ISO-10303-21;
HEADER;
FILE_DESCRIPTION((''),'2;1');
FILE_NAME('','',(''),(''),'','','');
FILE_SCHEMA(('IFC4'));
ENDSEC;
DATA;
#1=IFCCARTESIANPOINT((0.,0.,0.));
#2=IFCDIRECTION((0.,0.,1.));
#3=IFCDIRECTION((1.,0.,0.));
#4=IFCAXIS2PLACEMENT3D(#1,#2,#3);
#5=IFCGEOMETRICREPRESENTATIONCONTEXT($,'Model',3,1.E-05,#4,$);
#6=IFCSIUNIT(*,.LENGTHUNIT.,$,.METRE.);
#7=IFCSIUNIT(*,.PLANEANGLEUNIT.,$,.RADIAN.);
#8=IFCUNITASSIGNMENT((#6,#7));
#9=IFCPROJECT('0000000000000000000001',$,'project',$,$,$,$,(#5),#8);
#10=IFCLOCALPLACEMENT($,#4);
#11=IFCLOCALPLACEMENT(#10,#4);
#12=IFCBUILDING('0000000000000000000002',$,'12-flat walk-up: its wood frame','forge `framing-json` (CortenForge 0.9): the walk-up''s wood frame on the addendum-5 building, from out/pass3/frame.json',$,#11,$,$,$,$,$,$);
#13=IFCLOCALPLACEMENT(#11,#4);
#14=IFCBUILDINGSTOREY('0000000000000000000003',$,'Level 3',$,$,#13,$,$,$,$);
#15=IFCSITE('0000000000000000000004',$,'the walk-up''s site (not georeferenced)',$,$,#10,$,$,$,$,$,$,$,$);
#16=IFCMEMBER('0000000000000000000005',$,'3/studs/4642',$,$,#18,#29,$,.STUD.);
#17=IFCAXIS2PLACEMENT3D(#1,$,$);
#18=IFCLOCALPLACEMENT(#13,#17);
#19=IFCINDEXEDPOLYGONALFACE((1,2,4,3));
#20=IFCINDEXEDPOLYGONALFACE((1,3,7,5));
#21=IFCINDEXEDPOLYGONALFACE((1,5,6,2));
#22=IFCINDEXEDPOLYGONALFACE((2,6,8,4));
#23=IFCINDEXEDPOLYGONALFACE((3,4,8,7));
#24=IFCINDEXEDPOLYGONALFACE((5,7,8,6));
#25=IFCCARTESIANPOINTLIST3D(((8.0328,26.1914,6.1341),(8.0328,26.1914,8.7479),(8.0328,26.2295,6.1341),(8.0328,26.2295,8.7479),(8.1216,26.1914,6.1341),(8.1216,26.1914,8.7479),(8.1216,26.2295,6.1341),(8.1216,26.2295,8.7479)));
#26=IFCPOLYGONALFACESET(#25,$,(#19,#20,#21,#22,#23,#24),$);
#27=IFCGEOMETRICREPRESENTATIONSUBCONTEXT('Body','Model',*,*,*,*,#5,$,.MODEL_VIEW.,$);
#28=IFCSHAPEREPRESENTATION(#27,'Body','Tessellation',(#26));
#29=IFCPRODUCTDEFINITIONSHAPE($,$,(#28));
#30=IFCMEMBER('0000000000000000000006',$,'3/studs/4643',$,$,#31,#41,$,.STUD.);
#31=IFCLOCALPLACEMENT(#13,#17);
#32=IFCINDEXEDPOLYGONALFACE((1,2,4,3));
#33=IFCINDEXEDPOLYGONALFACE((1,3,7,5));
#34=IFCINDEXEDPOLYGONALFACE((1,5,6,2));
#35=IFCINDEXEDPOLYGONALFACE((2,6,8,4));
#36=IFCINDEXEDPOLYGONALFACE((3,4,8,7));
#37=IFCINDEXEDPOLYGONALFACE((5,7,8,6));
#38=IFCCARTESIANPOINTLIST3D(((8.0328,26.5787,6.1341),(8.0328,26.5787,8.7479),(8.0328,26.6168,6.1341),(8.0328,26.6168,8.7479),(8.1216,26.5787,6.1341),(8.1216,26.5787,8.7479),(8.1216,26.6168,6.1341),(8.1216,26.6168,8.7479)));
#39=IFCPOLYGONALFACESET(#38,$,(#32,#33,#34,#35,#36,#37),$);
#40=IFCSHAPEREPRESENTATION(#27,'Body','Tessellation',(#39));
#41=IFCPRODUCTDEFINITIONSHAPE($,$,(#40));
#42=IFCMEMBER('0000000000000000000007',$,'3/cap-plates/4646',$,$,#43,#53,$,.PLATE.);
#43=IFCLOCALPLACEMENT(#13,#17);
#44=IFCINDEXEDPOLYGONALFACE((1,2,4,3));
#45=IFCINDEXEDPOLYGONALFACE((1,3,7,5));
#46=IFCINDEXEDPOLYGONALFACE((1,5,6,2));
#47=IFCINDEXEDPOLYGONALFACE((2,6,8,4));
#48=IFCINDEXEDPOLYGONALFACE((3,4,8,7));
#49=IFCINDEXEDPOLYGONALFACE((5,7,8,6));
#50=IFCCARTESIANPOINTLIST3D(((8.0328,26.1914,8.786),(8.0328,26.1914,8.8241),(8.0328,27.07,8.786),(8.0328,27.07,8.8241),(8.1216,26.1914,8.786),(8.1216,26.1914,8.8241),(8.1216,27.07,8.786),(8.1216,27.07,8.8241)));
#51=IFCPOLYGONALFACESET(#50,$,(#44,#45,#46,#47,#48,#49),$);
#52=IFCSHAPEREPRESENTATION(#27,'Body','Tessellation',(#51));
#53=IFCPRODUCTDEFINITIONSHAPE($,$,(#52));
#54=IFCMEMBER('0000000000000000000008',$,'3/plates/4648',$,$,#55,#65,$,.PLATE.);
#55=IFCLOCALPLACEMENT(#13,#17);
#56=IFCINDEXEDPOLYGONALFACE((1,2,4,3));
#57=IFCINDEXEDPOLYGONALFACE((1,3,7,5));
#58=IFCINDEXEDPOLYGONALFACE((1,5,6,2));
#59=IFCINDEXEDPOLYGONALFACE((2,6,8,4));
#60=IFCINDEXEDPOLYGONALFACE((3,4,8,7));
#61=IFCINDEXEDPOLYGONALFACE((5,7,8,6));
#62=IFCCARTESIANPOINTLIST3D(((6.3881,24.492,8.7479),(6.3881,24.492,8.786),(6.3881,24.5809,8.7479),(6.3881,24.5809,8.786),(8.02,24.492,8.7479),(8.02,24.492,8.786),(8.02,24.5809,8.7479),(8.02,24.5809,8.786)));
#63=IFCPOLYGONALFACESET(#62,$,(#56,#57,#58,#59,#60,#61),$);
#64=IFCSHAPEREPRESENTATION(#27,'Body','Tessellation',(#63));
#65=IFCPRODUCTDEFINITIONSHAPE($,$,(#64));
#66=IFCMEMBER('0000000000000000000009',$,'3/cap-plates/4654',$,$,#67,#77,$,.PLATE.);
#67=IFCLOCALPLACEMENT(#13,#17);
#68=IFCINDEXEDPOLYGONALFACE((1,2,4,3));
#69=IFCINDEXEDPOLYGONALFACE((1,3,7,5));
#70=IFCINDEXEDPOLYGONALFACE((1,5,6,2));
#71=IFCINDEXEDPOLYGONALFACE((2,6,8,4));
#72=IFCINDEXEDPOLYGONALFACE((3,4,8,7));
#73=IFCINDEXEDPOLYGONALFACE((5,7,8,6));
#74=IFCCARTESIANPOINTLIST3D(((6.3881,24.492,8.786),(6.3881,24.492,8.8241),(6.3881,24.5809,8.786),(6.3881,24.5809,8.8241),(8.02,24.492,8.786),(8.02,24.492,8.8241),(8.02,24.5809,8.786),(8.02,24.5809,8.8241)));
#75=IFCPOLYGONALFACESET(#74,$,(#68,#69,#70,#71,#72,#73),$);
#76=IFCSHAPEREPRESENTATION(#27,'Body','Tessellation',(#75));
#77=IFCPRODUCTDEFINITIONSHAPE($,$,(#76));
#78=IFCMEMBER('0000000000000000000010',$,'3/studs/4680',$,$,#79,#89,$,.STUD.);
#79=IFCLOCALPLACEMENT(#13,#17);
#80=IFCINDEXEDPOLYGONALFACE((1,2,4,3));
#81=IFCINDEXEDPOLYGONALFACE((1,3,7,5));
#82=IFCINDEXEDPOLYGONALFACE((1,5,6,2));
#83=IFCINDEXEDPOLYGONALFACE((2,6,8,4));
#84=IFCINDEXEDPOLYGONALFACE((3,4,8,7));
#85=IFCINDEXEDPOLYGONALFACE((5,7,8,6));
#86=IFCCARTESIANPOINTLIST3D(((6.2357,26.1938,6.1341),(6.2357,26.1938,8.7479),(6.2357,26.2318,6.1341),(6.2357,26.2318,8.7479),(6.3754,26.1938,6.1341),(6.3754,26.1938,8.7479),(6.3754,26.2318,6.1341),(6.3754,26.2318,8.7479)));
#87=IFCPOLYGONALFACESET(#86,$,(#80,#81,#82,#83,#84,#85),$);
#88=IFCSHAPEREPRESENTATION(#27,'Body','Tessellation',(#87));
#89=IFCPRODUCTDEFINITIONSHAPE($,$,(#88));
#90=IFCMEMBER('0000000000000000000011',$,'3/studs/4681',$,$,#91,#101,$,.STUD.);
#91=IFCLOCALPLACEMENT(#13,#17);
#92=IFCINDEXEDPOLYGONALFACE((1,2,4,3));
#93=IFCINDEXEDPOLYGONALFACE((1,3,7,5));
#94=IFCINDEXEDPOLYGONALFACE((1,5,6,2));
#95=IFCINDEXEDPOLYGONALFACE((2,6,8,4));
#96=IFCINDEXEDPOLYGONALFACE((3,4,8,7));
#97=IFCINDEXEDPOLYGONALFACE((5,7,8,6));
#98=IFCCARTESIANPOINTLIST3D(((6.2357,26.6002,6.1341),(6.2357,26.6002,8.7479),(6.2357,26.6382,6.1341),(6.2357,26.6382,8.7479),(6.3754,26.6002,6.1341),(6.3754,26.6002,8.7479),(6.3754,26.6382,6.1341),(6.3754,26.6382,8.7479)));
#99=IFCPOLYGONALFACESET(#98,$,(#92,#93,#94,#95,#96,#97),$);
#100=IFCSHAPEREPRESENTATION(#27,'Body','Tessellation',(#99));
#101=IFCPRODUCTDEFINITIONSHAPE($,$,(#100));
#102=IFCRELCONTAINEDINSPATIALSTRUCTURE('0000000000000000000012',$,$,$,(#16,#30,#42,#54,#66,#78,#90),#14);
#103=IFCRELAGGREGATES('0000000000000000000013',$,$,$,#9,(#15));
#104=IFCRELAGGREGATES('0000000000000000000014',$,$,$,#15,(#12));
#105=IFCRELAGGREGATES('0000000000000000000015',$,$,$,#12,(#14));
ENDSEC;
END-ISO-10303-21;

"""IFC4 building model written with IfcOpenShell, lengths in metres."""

from ifc_helpers import new_model, si_unit, frame, frame_2d, origin, origin_with_axes, place, context, subcontext, project, spatial, rectangle, extrude, element, save


model = new_model("IFC4")

# Units and contexts
model_context = context("Model", 3, precision=1e-05, world=origin_with_axes())
body_context = subcontext(model_context, "Body", "Model", "MODEL_VIEW")
ifc_project = project(units=[si_unit("LENGTHUNIT", "METRE"), si_unit("PLANEANGLEUNIT", "RADIAN")], contexts=[model_context])

# Site, building, storey
site_placement = place(None, origin_with_axes())
site = spatial("IfcSite", under=ifc_project, at=site_placement, Name="the walk-up's site (not georeferenced)")
building_placement = place(site_placement, origin_with_axes())
building = spatial("IfcBuilding", under=site, at=building_placement, Name="12-flat walk-up: its wood frame", Description="forge `framing-json` (CortenForge 0.9): the walk-up's wood frame on the addendum-5 building, from out/pass3/frame.json")
storey_placement = place(building_placement, origin_with_axes())
storey = spatial("IfcBuildingStorey", under=building, at=storey_placement, Name="Level 3")

# Members
for number, where, z_axis, x_axis, name in (
    (1, (8.0328, 26.1914, 6.1341), (0.0, 0.0, 1.0), (1.0, 0.0, 0.0), "3/studs/4642"),
    (2, (8.0328, 26.5787, 6.1341), (0.0, 0.0, 1.0), (1.0, 0.0, 0.0), "3/studs/4643"),
):
    element("IfcMember", number, at=place(storey_placement, frame(where, z_axis=z_axis, x_axis=x_axis)), inside=storey, Name=name, PredefinedType="STUD", context=body_context, shape_type="SweptSolid", body=[
        extrude(rectangle(XDim=0.0889, YDim=0.0381, at=frame_2d((0.0445, 0.0191))), origin(), (0.0, 0.0, 1.0), 2.6138),
    ])
member_1_placement = place(storey_placement, frame((8.0328, 26.1914, 8.786), z_axis=(0.0, 0.0, 1.0), x_axis=(1.0, 0.0, 0.0)))
element("IfcMember", 3, at=member_1_placement, inside=storey, Name="3/cap-plates/4646", PredefinedType="PLATE", context=body_context, shape_type="SweptSolid", body=[
    extrude(rectangle(XDim=0.0889, YDim=0.8787, at=frame_2d((0.0445, 0.4393))), origin(), (0.0, 0.0, 1.0), 0.0381),
])
for number, where, z_axis, x_axis, name in (
    (4, (6.3881, 24.4919, 8.7479), (0.0, 0.0, 1.0), (1.0, 0.0, 0.0), "3/plates/4648"),
    (5, (6.3881, 24.4919, 8.786), (0.0, 0.0, 1.0), (1.0, 0.0, 0.0), "3/cap-plates/4654"),
):
    element("IfcMember", number, at=place(storey_placement, frame(where, z_axis=z_axis, x_axis=x_axis)), inside=storey, Name=name, PredefinedType="PLATE", context=body_context, shape_type="SweptSolid", body=[
        extrude(rectangle(XDim=1.6319, YDim=0.0889, at=frame_2d((0.816, 0.0445))), origin(), (0.0, 0.0, 1.0), 0.0381),
    ])
for number, where, z_axis, x_axis, name in (
    (6, (6.2357, 26.1938, 6.1341), (0.0, 0.0, 1.0), (1.0, 0.0, 0.0), "3/studs/4680"),
    (7, (6.2357, 26.6001, 6.1341), (0.0, 0.0, 1.0), (1.0, 0.0, 0.0), "3/studs/4681"),
):
    element("IfcMember", number, at=place(storey_placement, frame(where, z_axis=z_axis, x_axis=x_axis)), inside=storey, Name=name, PredefinedType="STUD", context=body_context, shape_type="SweptSolid", body=[
        extrude(rectangle(XDim=0.1397, YDim=0.0381, at=frame_2d((0.0699, 0.0191))), origin(), (0.0, 0.0, 1.0), 2.6138),
    ])

save(model, "model.ifc")
